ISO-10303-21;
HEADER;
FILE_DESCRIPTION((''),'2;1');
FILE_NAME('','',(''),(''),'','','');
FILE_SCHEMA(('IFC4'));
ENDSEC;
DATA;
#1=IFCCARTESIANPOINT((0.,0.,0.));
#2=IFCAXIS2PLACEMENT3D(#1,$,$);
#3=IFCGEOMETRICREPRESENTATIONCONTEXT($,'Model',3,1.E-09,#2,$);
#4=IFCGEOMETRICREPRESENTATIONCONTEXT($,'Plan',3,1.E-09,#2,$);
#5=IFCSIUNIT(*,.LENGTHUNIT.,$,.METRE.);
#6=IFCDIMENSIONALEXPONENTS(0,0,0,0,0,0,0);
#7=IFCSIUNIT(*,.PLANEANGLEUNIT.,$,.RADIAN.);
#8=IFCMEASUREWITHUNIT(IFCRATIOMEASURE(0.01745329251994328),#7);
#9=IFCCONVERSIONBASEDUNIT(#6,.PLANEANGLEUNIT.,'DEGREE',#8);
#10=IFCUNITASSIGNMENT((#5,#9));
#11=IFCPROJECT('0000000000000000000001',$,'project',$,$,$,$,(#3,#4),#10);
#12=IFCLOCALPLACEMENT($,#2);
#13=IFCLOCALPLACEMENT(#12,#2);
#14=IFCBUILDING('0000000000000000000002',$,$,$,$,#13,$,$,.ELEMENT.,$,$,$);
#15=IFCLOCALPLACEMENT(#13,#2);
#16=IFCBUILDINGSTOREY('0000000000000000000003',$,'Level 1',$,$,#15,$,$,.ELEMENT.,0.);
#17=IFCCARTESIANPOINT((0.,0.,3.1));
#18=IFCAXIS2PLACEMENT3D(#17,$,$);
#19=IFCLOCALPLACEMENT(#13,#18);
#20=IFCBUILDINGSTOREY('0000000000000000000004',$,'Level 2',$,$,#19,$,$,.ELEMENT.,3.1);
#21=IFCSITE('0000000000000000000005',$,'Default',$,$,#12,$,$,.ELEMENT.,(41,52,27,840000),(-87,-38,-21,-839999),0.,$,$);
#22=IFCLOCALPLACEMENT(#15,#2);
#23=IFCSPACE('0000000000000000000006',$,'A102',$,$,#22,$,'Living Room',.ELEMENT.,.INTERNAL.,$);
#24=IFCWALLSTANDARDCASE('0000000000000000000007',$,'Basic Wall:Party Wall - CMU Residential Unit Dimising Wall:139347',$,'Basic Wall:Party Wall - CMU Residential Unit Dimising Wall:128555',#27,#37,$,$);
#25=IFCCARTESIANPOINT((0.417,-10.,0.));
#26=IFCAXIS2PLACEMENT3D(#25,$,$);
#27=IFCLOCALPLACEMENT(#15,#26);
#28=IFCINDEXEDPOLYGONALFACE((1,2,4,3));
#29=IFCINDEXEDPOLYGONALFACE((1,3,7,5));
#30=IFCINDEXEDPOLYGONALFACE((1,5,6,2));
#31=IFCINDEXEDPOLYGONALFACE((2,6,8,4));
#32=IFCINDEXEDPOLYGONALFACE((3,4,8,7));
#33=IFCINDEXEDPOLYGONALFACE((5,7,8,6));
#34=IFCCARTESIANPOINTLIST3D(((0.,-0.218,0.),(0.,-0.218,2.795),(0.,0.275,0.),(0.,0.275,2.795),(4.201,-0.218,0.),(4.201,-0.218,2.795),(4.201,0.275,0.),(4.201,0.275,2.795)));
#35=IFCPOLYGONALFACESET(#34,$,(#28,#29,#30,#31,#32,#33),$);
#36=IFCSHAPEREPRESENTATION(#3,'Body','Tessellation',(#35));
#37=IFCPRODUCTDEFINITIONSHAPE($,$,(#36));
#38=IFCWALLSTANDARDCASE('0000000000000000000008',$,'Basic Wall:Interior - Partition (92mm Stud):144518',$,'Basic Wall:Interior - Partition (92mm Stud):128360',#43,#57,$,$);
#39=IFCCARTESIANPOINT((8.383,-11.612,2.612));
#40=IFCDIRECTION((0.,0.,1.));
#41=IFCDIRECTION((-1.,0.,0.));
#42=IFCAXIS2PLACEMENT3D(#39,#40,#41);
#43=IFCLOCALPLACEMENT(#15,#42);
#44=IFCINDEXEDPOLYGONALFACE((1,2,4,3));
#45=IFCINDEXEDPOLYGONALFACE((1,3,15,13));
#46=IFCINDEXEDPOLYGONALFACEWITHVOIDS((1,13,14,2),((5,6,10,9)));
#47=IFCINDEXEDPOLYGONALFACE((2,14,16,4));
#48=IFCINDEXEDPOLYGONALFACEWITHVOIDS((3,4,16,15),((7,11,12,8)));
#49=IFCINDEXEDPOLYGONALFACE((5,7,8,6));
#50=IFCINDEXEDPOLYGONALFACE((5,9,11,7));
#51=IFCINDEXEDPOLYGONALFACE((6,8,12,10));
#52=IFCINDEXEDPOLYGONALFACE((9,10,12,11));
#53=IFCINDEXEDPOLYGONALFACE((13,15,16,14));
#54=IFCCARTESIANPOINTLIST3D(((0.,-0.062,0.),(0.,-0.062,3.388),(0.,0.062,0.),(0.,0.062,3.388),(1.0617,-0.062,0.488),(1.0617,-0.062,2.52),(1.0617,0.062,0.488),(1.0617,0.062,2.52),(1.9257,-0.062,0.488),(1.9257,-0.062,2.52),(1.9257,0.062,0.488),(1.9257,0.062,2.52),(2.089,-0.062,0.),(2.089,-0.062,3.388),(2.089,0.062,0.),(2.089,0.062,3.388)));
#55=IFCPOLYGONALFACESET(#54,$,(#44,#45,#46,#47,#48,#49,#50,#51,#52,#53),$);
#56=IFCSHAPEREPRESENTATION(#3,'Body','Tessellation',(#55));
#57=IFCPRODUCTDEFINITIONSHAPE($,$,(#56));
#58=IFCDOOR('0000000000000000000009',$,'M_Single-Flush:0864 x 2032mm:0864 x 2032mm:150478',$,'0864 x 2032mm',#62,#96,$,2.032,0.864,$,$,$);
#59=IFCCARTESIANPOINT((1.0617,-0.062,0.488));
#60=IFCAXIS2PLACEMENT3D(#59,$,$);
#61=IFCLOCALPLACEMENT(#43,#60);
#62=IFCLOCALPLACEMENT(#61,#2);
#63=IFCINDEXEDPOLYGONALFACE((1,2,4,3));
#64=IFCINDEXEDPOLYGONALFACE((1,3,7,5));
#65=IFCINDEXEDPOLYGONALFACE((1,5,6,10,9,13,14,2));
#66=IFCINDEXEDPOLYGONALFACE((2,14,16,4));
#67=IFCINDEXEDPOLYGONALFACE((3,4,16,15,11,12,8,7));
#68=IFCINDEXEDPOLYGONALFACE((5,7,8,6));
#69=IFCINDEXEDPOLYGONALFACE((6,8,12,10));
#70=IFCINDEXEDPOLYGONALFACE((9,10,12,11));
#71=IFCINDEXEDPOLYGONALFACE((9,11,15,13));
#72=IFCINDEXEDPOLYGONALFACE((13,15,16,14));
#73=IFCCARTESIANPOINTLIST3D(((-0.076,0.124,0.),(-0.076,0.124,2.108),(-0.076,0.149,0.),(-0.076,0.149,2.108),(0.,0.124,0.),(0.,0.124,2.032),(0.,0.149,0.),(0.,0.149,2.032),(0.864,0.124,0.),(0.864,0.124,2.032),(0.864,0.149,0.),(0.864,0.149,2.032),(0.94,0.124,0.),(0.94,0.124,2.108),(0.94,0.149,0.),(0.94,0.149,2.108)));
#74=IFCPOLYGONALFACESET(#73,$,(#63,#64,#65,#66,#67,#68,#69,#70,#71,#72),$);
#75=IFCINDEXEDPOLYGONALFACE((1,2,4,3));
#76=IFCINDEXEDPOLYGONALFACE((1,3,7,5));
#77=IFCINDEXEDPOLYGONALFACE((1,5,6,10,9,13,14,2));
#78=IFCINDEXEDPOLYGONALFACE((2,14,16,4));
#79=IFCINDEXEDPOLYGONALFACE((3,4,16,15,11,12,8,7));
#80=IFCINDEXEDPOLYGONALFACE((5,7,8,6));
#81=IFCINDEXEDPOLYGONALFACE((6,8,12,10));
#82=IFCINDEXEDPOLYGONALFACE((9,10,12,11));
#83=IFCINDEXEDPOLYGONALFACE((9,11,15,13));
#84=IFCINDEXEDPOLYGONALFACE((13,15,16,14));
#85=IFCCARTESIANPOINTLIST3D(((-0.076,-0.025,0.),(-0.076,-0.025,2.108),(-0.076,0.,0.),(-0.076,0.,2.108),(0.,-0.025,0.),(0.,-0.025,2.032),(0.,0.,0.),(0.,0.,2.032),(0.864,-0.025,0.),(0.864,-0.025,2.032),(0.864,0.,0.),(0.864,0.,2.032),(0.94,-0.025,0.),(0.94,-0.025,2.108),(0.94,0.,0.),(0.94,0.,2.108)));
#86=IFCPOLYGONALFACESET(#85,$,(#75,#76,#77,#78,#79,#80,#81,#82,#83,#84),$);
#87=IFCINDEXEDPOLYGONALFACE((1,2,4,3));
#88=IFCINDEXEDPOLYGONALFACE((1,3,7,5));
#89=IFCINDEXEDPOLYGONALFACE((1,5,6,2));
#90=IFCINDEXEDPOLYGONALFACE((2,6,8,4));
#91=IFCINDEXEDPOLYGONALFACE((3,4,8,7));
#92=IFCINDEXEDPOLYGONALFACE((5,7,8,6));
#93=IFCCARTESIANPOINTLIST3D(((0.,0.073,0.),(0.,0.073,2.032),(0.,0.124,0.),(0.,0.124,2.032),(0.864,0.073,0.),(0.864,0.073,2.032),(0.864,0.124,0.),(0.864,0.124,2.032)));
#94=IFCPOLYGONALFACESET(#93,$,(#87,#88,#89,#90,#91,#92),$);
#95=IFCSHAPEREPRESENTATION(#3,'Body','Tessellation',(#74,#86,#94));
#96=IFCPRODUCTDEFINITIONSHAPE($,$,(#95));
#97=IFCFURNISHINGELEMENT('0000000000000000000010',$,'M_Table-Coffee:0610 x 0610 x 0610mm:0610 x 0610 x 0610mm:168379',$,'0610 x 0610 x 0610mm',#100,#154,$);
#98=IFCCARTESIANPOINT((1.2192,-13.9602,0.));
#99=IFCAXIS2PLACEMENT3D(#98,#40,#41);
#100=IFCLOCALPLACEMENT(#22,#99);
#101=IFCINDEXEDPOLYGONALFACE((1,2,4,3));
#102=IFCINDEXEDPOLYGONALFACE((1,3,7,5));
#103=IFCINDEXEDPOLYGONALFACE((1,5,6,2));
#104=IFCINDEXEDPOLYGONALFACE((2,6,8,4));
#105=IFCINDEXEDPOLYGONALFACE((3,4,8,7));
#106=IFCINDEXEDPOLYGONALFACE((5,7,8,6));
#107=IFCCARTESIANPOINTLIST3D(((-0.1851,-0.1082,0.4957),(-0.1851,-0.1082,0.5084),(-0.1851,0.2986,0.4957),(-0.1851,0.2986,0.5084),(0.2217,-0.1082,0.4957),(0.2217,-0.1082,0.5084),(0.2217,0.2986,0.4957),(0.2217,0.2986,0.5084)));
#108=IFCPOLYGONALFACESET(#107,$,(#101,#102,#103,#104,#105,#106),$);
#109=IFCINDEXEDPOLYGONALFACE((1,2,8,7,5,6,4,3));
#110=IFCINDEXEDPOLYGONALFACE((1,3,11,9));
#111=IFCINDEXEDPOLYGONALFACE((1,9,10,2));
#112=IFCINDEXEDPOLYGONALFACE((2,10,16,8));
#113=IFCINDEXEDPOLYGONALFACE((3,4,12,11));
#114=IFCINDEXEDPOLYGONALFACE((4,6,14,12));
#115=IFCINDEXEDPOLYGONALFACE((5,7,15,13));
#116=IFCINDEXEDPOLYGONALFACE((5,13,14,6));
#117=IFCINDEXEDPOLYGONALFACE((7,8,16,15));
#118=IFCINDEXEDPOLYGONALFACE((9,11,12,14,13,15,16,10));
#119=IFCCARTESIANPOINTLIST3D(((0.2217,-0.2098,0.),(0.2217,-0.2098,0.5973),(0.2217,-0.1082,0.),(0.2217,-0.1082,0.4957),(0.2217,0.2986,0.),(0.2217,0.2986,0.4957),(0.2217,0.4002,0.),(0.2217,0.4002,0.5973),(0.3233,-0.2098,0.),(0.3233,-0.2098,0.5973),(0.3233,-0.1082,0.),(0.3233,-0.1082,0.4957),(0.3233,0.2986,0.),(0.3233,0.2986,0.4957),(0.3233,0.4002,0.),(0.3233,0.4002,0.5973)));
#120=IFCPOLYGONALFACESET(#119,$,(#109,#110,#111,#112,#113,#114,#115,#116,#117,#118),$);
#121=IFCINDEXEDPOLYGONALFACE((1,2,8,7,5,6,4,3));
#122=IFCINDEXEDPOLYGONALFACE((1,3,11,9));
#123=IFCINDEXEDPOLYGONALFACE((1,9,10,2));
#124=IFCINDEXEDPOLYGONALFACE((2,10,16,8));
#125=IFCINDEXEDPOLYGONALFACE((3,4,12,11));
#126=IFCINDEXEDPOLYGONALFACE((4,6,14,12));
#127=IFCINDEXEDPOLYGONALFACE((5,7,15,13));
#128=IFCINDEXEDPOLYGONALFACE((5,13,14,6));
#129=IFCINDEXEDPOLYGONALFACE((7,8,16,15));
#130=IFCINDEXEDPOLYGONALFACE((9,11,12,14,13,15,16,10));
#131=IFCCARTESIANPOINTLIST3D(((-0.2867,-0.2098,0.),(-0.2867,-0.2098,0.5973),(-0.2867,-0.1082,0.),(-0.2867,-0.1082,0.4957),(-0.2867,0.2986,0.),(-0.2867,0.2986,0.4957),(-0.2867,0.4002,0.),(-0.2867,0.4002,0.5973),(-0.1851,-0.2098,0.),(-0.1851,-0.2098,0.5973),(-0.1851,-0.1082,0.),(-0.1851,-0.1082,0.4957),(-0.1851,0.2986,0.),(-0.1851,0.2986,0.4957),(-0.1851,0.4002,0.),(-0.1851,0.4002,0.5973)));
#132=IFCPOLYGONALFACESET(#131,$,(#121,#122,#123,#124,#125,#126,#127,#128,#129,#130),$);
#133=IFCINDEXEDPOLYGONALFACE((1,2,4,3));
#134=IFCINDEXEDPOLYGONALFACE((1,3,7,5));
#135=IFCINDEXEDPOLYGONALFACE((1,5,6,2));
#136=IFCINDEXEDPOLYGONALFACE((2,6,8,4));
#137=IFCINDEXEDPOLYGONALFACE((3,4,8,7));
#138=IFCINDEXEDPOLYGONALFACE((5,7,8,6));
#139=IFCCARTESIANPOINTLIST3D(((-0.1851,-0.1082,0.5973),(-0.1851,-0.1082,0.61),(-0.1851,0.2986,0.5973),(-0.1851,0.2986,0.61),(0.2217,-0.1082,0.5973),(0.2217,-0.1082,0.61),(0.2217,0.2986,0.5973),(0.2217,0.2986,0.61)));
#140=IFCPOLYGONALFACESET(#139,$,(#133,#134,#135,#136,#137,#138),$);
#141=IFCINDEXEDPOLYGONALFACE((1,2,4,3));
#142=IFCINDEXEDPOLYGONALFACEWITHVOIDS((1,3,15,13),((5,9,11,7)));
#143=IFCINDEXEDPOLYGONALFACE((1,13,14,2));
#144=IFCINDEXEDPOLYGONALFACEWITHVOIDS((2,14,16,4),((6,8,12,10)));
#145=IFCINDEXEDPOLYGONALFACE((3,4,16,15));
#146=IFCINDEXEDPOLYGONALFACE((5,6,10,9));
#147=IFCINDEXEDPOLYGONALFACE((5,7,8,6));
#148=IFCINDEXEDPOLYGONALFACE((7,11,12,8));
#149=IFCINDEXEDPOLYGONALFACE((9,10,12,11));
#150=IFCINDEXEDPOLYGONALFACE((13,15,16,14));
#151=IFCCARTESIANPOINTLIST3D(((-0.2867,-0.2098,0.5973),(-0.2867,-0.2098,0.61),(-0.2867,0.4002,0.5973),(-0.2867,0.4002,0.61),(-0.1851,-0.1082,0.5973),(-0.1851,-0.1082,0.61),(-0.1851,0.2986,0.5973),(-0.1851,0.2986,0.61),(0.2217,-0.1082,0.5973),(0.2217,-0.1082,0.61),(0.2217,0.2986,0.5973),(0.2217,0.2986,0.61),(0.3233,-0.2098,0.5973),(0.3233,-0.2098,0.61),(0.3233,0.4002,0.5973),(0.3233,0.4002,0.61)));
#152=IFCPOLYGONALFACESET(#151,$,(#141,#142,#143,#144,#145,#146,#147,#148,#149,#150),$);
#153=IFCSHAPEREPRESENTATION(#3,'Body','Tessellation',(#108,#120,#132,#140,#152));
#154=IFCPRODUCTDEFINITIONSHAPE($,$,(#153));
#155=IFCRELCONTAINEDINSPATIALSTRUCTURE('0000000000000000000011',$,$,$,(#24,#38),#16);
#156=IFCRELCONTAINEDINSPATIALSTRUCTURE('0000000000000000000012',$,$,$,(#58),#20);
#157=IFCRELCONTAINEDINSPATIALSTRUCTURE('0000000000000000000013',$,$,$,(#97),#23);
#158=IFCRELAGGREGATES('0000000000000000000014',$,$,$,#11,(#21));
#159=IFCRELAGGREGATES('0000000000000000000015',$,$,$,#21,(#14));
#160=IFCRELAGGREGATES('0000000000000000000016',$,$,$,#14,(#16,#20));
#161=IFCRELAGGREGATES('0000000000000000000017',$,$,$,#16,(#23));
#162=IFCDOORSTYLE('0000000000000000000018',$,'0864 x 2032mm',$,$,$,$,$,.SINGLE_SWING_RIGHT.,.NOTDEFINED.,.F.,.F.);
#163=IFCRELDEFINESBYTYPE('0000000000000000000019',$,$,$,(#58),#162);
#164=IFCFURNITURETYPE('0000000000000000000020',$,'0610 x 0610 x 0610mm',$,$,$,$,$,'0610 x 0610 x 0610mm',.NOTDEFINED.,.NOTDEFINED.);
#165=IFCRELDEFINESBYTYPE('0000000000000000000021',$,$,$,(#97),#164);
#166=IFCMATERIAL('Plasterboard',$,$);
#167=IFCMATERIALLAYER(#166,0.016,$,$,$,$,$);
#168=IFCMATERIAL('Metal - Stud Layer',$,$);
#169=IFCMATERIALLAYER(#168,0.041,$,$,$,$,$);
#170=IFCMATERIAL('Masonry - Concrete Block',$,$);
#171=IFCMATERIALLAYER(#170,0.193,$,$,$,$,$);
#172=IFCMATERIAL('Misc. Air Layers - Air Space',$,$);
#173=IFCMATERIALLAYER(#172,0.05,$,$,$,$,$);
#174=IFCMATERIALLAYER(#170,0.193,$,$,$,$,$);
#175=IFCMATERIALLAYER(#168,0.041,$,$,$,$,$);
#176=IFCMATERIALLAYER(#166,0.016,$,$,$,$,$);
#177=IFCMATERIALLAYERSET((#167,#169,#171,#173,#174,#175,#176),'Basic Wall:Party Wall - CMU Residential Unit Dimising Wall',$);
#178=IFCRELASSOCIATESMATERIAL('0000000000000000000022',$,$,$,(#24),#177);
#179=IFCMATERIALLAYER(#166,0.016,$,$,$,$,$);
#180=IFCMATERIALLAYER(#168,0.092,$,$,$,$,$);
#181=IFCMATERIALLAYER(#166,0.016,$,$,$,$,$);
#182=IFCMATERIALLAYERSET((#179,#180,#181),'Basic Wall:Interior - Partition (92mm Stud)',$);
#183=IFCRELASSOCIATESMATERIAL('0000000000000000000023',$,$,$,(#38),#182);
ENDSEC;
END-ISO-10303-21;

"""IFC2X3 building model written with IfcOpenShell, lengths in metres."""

from ifc_helpers import new_model, entity, si_unit, converted_unit, frame, frame_2d, origin, origin_2d_with_axis, place, context, project, spatial, polyline, rectangle, outline, extrude, clip, bounded_halfspace, source, transform, mapped, material, layer, layer_set, layer_usage, type_object, type_shapes, element, fill, save


model = new_model("IFC2X3")

# Units and contexts
model_context = context("Model", 3, precision=1e-09, world=origin())
plan_context = context("Plan", 3, precision=1e-09, world=origin())
ifc_project = project(units=[si_unit("LENGTHUNIT", "METRE"), converted_unit("PLANEANGLEUNIT", "DEGREE", entity("IfcRatioMeasure", 0.01745329251994328), si_unit("PLANEANGLEUNIT", "RADIAN"), dimensions=[0, 0, 0, 0, 0, 0, 0])], contexts=[model_context, plan_context])

# Site, building, storey
site_placement = place(None, origin())
site = spatial("IfcSite", under=ifc_project, at=site_placement, Name="Default", CompositionType="ELEMENT", RefLatitude=(41, 52, 27, 840000), RefLongitude=(-87, -38, -21, -839999), RefElevation=0.0)
building_placement = place(site_placement, origin())
building = spatial("IfcBuilding", under=site, at=building_placement, CompositionType="ELEMENT")
storey_1_placement = place(building_placement, origin())
storey_1 = spatial("IfcBuildingStorey", under=building, at=storey_1_placement, Name="Level 1", CompositionType="ELEMENT", Elevation=0.0)

# Shared definitions
ifc_material_1 = material(Name="Misc. Air Layers - Air Space")
ifc_material_2 = material(Name="Masonry - Concrete Block")
ifc_material_3 = material(Name="Metal - Stud Layer")
ifc_material_4 = material(Name="Plasterboard")

# Wall
ifc_layer_1 = layer(ifc_material_4, 0.016)
ifc_layer_2 = layer(ifc_material_3, 0.041)
ifc_layer_3 = layer(ifc_material_2, 0.193)
ifc_layer_4 = layer(ifc_material_1, 0.05)
ifc_layer_5 = layer(ifc_material_2, 0.193)
ifc_layer_6 = layer(ifc_material_3, 0.041)
ifc_layer_7 = layer(ifc_material_4, 0.016)
ifc_layer_set_1 = layer_set([ifc_layer_1, ifc_layer_2, ifc_layer_3, ifc_layer_4, ifc_layer_5, ifc_layer_6, ifc_layer_7], Name="Basic Wall:Party Wall - CMU Residential Unit Dimising Wall")
ifc_layer_usage_1 = layer_usage(ifc_layer_set_1, "AXIS2", "NEGATIVE", 0.275)
wall_1_placement = place(storey_1_placement, frame((0.417, -10.0, 0.0)))
element("IfcWallStandardCase", 1, at=wall_1_placement, inside=storey_1, material=ifc_layer_usage_1, Name="Basic Wall:Party Wall - CMU Residential Unit Dimising Wall:139347", ObjectType="Basic Wall:Party Wall - CMU Residential Unit Dimising Wall:128555", context=model_context, shape_type="Clipping", body=[
    clip(clip(extrude(rectangle(XDim=4.201, YDim=0.55, at=frame_2d((2.1005, 0.0), x_axis=(-1.0, 0.0))), origin(), (0.0, 0.0, 1.0), 2.795), bounded_halfspace(frame((0.0, -0.218, 0.0), z_axis=(0.0, 1.0, 0.0), x_axis=(-1.0, 0.0, 0.0)), True, frame((0.0, -0.218, 0.0), z_axis=(0.0, 1.0, 0.0), x_axis=(-1.0, 0.0, 0.0)), polyline([(0.0, 0.0), (0.0, 2.795), (-4.201, 2.795), (-4.201, 0.0), (0.0, 0.0)]))), bounded_halfspace(frame((4.201, 0.275, 0.0), z_axis=(-1.0, 0.0, 0.0), x_axis=(0.0, -1.0, 0.0)), True, frame((4.201, 0.275, 0.0), z_axis=(-1.0, 0.0, 0.0), x_axis=(0.0, -1.0, 0.0)), polyline([(0.0, 0.0), (0.493, 0.0), (0.493, 2.795), (0.0, 2.795), (0.0, 0.0)]))),
])

# Shared definitions
ifc_layer_8 = layer(ifc_material_4, 0.016)
ifc_layer_9 = layer(ifc_material_3, 0.092)
ifc_layer_10 = layer(ifc_material_4, 0.016)
ifc_layer_set_2 = layer_set([ifc_layer_8, ifc_layer_9, ifc_layer_10], Name="Basic Wall:Interior - Partition (92mm Stud)")
door_style_1 = type_object("IfcDoorStyle", Name="0864 x 2032mm", ConstructionType="NOTDEFINED", OperationType="SINGLE_SWING_RIGHT", ParameterTakesPrecedence=False, Sizeable=False)
shared_shape_1 = source(origin(), model_context, "Body", "SweptSolid", [
    extrude(outline(polyline([(-0.508, -1.073), (0.508, -1.073), (0.508, 1.035), (0.432, 1.035), (0.432, -0.997), (-0.432, -0.997), (-0.432, 1.035), (-0.508, 1.035), (-0.508, -1.073)])), frame((0.432, 0.124, 1.035), z_axis=(0.0, 1.0, 0.0), x_axis=(1.0, 0.0, 0.0)), (0.0, 0.0, 1.0), 0.025),
    extrude(outline(polyline([(-1.073, -0.508), (1.035, -0.508), (1.035, -0.432), (-0.997, -0.432), (-0.997, 0.432), (1.035, 0.432), (1.035, 0.508), (-1.073, 0.508), (-1.073, -0.508)])), frame((0.432, -0.025, 1.035), z_axis=(0.0, 1.0, 0.0), x_axis=(0.0, 0.0, -1.0)), (0.0, 0.0, 1.0), 0.025),
    extrude(rectangle(XDim=0.051, YDim=0.864, at=origin_2d_with_axis()), frame((0.432, 0.0985, 0.0), z_axis=(0.0, 0.0, 1.0), x_axis=(0.0, 1.0, 0.0)), (0.0, 0.0, 1.0), 2.032),
])
type_shapes(door_style_1, [shared_shape_1])

# Wall, opening
ifc_layer_usage_2 = layer_usage(ifc_layer_set_2, "AXIS2", "NEGATIVE", 0.062)
wall_2_placement = place(storey_1_placement, frame((8.383, -11.612, 2.612), z_axis=(0.0, 0.0, 1.0), x_axis=(-1.0, 0.0, 0.0)))
wall_2 = element("IfcWallStandardCase", 2, at=wall_2_placement, inside=storey_1, material=ifc_layer_usage_2, Name="Basic Wall:Interior - Partition (92mm Stud):144518", ObjectType="Basic Wall:Interior - Partition (92mm Stud):128360", context=model_context, shape_type="SweptSolid", body=[
    extrude(rectangle(XDim=2.089, YDim=0.124, at=frame_2d((1.0445, 0.0), x_axis=(-1.0, 0.0))), origin(), (0.0, 0.0, 1.0), 3.388),
])
opening_1_placement = place(wall_2_placement, frame((1.0617, -0.062, 0.488)))
opening_1 = element("IfcOpeningElement", 3, at=opening_1_placement, cuts=wall_2, ObjectType="Opening", context=model_context, shape_type="SweptSolid", body=[
    extrude(rectangle(XDim=0.864, YDim=2.032, at=frame_2d((1.016, 0.432), x_axis=(0.0, 1.0))), frame((0.0, 0.0, 0.0), z_axis=(0.0, 1.0, 0.0), x_axis=(0.0, 0.0, 1.0)), (0.0, 0.0, 1.0), 0.124),
])

# Shared definitions
storey_2_placement = place(building_placement, frame((0.0, 0.0, 3.1)))
storey_2 = spatial("IfcBuildingStorey", under=building, at=storey_2_placement, Name="Level 2", CompositionType="ELEMENT", Elevation=3.1)

# Door
door_1_placement = place(opening_1_placement, origin())
door_1 = element("IfcDoor", 4, at=door_1_placement, inside=storey_2, type_object=door_style_1, Name="M_Single-Flush:0864 x 2032mm:0864 x 2032mm:150478", ObjectType="0864 x 2032mm", OverallHeight=2.032, OverallWidth=0.864, context=model_context, shape_type="MappedRepresentation", body=[
    mapped(shared_shape_1, transform((0.0, 0.0, 0.0), scale=1.0)),
])
fill(opening_1, door_1)

# Shared definitions
space_1_placement = place(storey_1_placement, origin())
space_1 = spatial("IfcSpace", under=storey_1, at=space_1_placement, Name="A102", LongName="Living Room", CompositionType="ELEMENT", InteriorOrExteriorSpace="INTERNAL")

# Furnishing element
furniture_type_1 = type_object("IfcFurnitureType", Name="0610 x 0610 x 0610mm", ElementType="0610 x 0610 x 0610mm", AssemblyPlace="NOTDEFINED")
shared_shape_2 = source(origin(), model_context, "Body", "SweptSolid", [
    extrude(rectangle(XDim=0.4068, YDim=0.4068, at=origin_2d_with_axis()), frame((0.0183, 0.0952, 0.4957), z_axis=(0.0, 0.0, 1.0), x_axis=(-1.0, 0.0, 0.0)), (0.0, 0.0, 1.0), 0.0127),
    extrude(outline(polyline([(-0.2732, -0.305), (0.324, -0.305), (0.324, 0.305), (-0.2732, 0.305), (-0.2732, 0.2034), (0.2225, 0.2034), (0.2225, -0.2034), (-0.2732, -0.2034), (-0.2732, -0.305)])), frame((0.2217, 0.0952, 0.2732), z_axis=(1.0, 0.0, 0.0), x_axis=(0.0, 0.0, 1.0)), (0.0, 0.0, 1.0), 0.1016),
    extrude(outline(polyline([(-0.305, -0.3241), (0.305, -0.3241), (0.305, 0.2733), (0.2034, 0.2733), (0.2034, -0.2224), (-0.2034, -0.2224), (-0.2034, 0.2733), (-0.305, 0.2733), (-0.305, -0.3241)])), frame((-0.2867, 0.0952, 0.2733), z_axis=(1.0, 0.0, 0.0), x_axis=(0.0, -1.0, 0.0)), (0.0, 0.0, 1.0), 0.1016),
    extrude(rectangle(XDim=0.4068, YDim=0.4068, at=origin_2d_with_axis()), frame((0.0183, 0.0952, 0.5973), z_axis=(0.0, 0.0, 1.0), x_axis=(-1.0, 0.0, 0.0)), (0.0, 0.0, 1.0), 0.0127),
    extrude(outline(polyline([(-0.305, -0.305), (0.305, -0.305), (0.305, 0.305), (-0.305, 0.305), (-0.305, -0.305)]), holes=[polyline([(-0.2034, -0.2034), (-0.2034, 0.2034), (0.2034, 0.2034), (0.2034, -0.2034), (-0.2034, -0.2034)])]), frame((0.0183, 0.0952, 0.5973), z_axis=(0.0, 0.0, 1.0), x_axis=(-1.0, 0.0, 0.0)), (0.0, 0.0, 1.0), 0.0127),
])
type_shapes(furniture_type_1, [shared_shape_2])
for number, where, z_axis, x_axis, name in (
    (5, (1.2192, -13.9602, 0.0), (0.0, 0.0, 1.0), (-1.0, 0.0, 0.0), "M_Table-Coffee:0610 x 0610 x 0610mm:0610 x 0610 x 0610mm:168379"),
):
    element("IfcFurnishingElement", number, at=place(space_1_placement, frame(where, z_axis=z_axis, x_axis=x_axis)), inside=space_1, type_object=furniture_type_1, Name=name, ObjectType="0610 x 0610 x 0610mm", context=model_context, shape_type="MappedRepresentation", body=[
        mapped(shared_shape_2, transform((0.0, 0.0, 0.0), scale=1.0)),
    ])

save(model, "model.ifc")
